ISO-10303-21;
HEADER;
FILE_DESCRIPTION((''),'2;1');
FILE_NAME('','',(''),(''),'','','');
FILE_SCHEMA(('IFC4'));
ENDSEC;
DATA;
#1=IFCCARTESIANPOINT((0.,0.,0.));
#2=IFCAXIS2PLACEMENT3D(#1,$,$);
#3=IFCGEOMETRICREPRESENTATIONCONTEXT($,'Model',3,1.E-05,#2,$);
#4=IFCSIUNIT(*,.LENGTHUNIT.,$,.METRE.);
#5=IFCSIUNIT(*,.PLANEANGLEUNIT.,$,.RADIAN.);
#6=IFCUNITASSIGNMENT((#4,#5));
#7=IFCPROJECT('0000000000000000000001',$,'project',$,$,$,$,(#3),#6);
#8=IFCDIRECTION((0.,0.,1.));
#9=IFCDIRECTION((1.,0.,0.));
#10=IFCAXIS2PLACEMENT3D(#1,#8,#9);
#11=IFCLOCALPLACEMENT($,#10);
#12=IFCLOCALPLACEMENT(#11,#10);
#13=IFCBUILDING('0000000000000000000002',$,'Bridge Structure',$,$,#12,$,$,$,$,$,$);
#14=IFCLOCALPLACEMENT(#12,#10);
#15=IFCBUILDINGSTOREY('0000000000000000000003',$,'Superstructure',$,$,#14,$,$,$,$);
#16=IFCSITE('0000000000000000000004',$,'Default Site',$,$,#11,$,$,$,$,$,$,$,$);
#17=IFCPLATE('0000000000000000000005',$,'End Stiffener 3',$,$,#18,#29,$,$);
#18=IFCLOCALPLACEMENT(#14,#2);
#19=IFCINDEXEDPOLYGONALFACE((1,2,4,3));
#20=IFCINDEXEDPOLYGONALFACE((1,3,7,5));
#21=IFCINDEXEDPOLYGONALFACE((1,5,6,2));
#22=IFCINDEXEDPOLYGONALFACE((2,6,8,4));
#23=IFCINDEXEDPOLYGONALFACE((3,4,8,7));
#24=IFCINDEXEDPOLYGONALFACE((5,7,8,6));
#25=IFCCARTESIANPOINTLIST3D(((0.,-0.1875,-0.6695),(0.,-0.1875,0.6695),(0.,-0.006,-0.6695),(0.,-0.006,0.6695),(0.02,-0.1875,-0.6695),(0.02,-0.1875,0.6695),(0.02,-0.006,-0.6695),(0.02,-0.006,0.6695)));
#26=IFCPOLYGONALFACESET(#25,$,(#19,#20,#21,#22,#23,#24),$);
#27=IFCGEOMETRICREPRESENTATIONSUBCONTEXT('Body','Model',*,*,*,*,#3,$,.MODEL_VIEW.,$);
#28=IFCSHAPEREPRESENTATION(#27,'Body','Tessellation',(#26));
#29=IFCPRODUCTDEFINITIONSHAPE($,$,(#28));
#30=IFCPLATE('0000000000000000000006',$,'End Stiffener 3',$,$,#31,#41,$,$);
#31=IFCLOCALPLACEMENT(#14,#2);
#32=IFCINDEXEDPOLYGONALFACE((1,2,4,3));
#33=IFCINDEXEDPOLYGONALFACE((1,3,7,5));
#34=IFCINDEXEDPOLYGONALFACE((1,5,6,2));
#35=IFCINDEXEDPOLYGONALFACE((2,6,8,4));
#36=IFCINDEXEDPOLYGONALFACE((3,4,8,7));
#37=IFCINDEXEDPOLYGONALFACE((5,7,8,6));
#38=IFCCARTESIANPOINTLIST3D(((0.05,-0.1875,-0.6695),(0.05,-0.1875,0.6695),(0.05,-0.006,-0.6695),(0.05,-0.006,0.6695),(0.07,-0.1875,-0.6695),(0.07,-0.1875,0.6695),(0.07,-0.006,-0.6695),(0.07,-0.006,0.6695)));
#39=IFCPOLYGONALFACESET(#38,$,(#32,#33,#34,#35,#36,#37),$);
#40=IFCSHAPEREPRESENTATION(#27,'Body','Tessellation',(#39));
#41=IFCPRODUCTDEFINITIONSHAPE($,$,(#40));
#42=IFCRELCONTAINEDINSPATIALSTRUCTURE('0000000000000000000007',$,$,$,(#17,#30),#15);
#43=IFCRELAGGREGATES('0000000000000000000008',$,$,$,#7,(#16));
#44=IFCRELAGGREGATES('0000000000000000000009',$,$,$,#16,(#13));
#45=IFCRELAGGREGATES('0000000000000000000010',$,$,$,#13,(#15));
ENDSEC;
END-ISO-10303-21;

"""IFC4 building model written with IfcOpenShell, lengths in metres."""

from ifc_helpers import new_model, si_unit, frame, origin, origin_with_axes, origin_2d_with_axis, place, context, subcontext, project, spatial, rectangle, extrude, element, save


model = new_model("IFC4")

# Units and contexts
model_context = context("Model", 3, precision=1e-05, world=origin())
body_context = subcontext(model_context, "Body", "Model", "MODEL_VIEW")
ifc_project = project(units=[si_unit("LENGTHUNIT", "METRE"), si_unit("PLANEANGLEUNIT", "RADIAN")], contexts=[model_context])

# Site, building, storey
site_placement = place(None, origin_with_axes())
site = spatial("IfcSite", under=ifc_project, at=site_placement, Name="Default Site")
building_placement = place(site_placement, origin_with_axes())
building = spatial("IfcBuilding", under=site, at=building_placement, Name="Bridge Structure")
storey_placement = place(building_placement, origin_with_axes())
storey = spatial("IfcBuildingStorey", under=building, at=storey_placement, Name="Superstructure")

# Plates
for number, where, z_axis, x_axis, name in (
    (1, (0.01, -0.0968, -0.6695), (0.0, 0.0, 1.0), (1.0, 0.0, 0.0), "End Stiffener 3"),
    (2, (0.06, -0.0968, -0.6695), (0.0, 0.0, 1.0), (1.0, 0.0, 0.0), "End Stiffener 3"),
):
    element("IfcPlate", number, at=place(storey_placement, frame(where, z_axis=z_axis, x_axis=x_axis)), inside=storey, Name=name, context=body_context, shape_type="SweptSolid", body=[
        extrude(rectangle(XDim=0.02, YDim=0.1815, at=origin_2d_with_axis()), origin_with_axes(), (0.0, 0.0, 1.0), 1.339),
    ])

save(model, "model.ifc")
